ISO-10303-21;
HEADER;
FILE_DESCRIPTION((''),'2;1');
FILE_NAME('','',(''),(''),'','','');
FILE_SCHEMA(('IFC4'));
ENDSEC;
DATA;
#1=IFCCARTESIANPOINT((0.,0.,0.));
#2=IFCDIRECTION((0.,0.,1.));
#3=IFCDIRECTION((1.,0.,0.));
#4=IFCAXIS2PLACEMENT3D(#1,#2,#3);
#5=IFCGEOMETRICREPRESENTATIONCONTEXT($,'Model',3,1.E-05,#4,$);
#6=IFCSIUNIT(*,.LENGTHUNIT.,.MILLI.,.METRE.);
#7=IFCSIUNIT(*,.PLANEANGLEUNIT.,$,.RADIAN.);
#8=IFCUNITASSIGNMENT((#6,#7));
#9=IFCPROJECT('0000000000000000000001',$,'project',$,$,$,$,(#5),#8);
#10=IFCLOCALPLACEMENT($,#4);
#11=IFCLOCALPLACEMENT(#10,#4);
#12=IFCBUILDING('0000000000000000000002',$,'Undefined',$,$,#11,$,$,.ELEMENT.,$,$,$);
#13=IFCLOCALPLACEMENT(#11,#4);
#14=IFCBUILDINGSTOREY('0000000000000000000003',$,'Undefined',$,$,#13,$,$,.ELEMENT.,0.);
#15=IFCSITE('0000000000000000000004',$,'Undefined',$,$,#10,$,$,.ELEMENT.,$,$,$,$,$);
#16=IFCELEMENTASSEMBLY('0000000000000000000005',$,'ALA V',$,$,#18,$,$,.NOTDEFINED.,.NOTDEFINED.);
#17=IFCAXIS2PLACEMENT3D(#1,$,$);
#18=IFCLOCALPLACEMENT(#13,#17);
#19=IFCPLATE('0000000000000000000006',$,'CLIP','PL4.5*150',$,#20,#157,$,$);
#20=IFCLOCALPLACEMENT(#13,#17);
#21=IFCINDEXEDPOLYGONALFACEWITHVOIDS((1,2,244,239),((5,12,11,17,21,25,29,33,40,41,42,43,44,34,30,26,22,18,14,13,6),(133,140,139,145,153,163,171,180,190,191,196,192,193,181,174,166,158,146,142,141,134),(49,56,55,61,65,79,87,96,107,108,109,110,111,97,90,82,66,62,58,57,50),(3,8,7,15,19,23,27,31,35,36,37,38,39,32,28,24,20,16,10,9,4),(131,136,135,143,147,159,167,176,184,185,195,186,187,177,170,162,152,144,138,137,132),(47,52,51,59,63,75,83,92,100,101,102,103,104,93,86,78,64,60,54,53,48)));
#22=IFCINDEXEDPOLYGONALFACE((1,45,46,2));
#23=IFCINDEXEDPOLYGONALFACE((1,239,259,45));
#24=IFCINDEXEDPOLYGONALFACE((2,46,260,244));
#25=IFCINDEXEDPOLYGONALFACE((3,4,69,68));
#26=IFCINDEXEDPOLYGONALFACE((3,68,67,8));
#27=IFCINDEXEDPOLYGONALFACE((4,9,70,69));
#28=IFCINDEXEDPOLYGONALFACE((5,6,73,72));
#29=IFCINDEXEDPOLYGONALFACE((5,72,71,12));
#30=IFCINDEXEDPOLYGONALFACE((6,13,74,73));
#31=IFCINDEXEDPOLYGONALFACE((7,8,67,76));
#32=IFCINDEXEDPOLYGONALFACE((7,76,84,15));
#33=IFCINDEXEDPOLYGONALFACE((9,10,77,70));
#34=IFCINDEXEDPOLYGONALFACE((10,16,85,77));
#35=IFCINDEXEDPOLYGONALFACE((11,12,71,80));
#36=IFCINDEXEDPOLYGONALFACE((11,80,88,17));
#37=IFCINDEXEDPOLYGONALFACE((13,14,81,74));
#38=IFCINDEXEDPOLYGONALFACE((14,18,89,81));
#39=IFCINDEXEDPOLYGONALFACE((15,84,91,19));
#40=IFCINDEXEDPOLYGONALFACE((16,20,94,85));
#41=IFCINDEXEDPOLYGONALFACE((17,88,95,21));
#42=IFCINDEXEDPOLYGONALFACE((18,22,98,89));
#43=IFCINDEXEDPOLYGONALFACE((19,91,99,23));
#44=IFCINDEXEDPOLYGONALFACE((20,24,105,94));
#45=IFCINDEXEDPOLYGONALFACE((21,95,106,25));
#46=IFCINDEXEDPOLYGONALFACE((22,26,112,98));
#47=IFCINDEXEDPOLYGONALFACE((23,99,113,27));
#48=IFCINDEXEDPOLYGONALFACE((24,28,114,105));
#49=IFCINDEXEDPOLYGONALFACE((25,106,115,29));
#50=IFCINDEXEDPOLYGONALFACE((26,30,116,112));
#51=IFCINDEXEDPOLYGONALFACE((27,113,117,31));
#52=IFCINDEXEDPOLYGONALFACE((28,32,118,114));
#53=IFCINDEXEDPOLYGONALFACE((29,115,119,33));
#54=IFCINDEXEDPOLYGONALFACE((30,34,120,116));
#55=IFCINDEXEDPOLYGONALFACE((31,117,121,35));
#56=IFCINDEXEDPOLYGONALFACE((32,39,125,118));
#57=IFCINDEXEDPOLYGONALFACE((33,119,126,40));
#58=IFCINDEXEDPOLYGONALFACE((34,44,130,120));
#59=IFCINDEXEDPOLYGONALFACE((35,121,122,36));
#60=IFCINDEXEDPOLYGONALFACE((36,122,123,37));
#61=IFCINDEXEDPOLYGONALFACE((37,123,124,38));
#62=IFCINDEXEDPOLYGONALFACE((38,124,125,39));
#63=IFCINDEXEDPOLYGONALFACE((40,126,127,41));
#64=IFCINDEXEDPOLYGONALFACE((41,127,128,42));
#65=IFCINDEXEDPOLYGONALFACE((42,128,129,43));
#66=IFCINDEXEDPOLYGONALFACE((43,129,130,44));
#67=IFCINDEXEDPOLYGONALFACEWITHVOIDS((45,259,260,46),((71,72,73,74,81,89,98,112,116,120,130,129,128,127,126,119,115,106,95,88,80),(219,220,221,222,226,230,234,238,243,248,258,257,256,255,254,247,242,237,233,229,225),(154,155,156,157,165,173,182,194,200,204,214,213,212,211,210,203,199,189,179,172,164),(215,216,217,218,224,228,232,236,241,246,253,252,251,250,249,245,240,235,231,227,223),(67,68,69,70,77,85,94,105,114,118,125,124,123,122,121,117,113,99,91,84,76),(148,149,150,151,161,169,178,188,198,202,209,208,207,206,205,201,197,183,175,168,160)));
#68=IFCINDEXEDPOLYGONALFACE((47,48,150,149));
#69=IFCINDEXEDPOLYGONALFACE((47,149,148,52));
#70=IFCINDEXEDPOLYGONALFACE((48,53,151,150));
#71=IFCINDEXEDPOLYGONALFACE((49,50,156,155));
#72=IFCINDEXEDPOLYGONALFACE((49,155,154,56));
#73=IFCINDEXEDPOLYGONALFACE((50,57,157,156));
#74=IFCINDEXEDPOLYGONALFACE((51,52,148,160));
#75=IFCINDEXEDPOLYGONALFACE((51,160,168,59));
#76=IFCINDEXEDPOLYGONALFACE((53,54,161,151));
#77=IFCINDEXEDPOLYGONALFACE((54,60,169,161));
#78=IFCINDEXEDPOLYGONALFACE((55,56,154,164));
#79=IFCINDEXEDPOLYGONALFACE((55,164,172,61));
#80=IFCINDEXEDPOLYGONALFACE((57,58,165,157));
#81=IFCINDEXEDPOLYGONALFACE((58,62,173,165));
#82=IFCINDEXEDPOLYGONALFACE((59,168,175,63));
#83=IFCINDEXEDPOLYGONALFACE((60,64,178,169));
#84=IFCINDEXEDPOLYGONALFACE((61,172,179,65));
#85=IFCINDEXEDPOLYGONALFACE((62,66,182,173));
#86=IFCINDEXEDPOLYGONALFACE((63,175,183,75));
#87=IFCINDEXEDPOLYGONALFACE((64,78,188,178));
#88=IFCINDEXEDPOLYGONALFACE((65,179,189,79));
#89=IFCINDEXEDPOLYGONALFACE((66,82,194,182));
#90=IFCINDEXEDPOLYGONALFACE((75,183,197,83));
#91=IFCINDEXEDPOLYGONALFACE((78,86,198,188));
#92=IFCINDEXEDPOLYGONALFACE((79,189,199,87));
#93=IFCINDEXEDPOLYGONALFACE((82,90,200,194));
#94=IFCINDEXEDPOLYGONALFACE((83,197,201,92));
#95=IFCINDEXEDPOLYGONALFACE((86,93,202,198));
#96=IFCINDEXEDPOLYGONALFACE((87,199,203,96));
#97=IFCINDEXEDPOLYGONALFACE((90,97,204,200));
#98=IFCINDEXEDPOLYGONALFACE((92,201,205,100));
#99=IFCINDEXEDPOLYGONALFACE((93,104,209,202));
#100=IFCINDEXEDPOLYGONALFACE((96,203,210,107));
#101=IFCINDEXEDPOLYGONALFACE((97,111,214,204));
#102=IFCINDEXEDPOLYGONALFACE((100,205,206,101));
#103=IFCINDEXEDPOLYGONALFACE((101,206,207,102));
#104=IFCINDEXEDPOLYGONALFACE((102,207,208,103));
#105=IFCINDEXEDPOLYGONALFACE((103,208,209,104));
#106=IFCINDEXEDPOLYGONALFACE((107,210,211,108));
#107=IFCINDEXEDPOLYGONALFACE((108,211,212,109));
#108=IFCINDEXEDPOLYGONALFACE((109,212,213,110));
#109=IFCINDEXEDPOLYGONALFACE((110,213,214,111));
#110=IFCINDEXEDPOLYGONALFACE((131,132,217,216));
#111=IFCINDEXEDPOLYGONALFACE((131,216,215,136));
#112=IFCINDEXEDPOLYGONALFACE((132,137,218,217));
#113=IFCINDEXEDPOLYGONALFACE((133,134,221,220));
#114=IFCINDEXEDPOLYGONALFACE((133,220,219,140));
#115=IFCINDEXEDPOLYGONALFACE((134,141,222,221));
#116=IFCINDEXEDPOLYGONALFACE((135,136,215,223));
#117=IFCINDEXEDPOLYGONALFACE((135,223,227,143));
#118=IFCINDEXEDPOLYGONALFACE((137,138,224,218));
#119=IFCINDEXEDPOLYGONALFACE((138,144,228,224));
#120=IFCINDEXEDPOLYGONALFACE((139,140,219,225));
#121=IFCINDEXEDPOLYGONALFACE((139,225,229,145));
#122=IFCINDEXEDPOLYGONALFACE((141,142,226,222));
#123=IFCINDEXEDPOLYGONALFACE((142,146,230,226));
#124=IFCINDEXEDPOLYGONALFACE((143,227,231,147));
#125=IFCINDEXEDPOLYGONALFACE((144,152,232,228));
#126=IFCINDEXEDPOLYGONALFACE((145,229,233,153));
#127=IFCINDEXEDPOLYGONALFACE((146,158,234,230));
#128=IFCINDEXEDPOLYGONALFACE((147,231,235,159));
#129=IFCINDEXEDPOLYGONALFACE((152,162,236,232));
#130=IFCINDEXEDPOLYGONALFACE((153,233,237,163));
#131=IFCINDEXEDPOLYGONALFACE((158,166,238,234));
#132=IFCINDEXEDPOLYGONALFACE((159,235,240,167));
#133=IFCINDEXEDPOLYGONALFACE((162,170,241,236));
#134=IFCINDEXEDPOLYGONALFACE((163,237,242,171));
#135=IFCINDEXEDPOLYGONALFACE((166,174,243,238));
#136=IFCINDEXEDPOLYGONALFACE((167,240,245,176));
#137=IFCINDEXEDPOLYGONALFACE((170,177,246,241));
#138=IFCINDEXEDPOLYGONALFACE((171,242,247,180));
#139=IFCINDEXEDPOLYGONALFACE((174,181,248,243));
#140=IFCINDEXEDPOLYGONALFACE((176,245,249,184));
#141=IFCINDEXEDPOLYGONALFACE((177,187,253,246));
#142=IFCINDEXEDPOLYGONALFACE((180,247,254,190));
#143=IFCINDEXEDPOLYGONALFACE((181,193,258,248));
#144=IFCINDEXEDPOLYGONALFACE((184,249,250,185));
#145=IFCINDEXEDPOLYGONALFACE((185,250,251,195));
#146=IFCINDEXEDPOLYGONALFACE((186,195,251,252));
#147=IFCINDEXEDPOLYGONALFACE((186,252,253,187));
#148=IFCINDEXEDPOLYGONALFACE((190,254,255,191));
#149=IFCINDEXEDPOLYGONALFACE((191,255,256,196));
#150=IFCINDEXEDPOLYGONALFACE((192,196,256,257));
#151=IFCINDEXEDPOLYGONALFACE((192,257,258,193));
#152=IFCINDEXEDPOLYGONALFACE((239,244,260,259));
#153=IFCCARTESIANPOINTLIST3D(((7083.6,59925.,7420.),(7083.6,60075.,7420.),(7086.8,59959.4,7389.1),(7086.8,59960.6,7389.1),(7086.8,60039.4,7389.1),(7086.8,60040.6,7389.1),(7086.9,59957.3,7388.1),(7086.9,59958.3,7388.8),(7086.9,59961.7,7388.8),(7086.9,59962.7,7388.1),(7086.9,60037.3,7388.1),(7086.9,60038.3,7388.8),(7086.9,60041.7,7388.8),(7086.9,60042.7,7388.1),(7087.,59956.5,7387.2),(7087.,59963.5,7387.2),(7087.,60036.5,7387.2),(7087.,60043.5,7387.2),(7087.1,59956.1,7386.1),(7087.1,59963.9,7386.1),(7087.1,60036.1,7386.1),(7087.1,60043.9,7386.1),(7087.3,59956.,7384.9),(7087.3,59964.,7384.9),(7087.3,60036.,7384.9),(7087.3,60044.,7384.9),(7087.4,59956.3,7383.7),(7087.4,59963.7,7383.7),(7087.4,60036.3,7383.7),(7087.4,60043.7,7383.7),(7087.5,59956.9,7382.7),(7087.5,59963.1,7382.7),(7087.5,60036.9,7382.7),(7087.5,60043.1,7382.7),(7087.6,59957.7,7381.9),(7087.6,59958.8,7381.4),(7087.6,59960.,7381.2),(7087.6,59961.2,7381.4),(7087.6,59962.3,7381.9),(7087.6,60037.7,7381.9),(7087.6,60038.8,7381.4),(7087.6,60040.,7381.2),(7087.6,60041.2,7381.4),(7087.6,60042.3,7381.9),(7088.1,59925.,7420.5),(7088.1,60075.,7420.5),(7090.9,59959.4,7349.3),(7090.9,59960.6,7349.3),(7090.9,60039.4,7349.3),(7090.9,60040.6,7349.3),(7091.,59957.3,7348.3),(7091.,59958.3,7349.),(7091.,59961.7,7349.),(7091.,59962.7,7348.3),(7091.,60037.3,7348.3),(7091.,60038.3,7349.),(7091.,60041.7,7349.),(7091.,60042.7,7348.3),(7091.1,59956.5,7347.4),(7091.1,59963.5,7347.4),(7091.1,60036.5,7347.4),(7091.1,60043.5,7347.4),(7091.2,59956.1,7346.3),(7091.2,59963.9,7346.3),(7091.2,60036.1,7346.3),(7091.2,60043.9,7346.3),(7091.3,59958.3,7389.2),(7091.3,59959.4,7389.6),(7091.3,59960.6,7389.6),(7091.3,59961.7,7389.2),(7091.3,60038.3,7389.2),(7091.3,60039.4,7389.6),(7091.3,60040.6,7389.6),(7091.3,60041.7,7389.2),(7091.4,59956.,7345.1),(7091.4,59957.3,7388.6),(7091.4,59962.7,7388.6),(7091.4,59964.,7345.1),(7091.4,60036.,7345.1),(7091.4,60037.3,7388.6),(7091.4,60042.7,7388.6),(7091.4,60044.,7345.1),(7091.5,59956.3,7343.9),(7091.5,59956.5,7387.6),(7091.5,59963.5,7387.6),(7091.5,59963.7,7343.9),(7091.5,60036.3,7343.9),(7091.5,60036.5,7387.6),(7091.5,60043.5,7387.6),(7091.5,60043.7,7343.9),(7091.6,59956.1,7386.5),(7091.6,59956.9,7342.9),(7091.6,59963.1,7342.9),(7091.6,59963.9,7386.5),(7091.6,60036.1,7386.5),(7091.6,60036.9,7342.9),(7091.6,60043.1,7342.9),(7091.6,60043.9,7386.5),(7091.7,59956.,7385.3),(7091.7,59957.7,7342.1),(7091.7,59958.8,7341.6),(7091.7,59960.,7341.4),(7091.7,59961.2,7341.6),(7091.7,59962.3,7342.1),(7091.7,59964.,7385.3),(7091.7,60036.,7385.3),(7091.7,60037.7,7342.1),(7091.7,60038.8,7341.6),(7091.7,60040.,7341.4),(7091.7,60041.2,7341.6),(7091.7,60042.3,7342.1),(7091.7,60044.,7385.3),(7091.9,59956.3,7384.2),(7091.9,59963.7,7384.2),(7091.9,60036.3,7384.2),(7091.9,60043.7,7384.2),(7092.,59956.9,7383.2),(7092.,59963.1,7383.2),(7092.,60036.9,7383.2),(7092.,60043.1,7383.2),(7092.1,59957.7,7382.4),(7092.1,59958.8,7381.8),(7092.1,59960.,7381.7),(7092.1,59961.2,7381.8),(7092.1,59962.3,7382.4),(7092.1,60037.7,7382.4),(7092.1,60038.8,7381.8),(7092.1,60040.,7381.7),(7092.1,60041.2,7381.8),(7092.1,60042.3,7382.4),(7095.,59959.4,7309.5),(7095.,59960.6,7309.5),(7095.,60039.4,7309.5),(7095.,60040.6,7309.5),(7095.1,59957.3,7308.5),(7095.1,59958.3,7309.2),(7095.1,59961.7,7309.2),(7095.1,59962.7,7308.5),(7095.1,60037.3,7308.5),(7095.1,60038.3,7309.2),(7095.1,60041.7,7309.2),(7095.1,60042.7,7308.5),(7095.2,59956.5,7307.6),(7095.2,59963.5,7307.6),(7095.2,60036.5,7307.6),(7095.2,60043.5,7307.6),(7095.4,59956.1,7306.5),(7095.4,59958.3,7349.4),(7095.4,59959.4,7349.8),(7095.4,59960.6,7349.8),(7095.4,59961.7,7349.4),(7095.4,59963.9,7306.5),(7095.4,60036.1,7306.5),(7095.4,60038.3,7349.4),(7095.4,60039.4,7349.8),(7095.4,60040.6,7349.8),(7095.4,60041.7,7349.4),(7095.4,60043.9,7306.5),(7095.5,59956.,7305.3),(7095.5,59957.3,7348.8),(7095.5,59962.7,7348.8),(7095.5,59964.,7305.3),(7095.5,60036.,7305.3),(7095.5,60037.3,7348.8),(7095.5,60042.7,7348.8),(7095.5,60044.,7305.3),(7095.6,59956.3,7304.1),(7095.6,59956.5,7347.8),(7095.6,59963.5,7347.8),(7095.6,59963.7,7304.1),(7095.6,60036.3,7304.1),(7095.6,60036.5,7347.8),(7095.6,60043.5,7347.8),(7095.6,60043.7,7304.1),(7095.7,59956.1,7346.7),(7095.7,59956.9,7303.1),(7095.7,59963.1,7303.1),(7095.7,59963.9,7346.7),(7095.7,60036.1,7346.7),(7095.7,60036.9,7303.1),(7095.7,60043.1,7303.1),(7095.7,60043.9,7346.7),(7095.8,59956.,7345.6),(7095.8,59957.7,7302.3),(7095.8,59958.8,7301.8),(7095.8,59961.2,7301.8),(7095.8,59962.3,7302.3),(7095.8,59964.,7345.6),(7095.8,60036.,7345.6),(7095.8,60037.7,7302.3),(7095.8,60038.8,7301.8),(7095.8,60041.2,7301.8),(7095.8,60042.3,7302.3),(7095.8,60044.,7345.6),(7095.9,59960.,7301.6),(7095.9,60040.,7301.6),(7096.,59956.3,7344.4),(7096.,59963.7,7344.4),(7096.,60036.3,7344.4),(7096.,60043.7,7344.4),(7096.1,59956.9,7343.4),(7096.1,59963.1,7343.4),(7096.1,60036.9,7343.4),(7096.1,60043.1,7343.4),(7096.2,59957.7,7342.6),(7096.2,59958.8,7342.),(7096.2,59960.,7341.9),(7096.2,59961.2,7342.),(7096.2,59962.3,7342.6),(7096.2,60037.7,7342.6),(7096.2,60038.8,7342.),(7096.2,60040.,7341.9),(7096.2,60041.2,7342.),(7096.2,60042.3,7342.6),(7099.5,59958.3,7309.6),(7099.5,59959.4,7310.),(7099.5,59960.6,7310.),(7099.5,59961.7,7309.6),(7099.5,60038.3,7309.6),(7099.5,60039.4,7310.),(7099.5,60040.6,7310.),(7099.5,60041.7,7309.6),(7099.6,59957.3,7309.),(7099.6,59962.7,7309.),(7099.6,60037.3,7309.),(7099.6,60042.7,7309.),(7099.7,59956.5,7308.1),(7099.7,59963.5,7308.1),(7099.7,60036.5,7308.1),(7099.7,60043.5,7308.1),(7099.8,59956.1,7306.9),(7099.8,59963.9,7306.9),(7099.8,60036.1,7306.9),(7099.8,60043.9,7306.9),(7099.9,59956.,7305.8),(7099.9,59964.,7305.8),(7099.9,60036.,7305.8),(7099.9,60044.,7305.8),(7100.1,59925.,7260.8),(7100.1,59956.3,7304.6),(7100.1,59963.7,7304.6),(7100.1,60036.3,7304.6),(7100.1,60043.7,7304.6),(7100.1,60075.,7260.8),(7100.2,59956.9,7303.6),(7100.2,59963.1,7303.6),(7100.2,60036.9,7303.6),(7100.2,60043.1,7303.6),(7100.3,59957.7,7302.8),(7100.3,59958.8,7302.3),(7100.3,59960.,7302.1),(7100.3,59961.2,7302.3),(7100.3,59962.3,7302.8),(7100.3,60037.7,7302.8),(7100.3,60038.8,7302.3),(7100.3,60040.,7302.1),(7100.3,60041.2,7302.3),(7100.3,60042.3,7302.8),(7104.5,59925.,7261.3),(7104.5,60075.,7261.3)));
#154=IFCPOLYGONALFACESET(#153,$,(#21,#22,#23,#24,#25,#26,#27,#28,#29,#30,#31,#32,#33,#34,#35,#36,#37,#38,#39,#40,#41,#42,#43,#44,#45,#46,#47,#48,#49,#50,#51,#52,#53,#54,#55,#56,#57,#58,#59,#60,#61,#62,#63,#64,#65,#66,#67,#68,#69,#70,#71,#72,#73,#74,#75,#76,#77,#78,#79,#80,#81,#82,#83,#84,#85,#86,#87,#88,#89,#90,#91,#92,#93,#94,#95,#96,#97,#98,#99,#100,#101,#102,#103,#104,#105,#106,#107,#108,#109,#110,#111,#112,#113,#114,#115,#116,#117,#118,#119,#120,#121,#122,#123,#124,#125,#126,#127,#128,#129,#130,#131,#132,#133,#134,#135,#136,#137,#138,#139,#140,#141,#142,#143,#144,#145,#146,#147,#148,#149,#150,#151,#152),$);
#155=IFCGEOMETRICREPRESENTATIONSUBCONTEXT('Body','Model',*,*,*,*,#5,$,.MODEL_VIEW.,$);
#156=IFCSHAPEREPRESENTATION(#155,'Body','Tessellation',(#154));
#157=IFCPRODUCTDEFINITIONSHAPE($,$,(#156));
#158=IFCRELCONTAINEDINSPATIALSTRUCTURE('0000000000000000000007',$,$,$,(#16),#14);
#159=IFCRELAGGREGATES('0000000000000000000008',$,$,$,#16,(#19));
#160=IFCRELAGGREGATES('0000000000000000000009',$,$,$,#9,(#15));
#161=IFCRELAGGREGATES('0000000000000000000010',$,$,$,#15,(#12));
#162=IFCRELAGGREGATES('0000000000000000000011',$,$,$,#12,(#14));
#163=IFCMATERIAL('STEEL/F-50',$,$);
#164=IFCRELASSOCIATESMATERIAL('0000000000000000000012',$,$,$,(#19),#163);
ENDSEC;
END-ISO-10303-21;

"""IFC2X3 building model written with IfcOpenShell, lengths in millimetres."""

from ifc_helpers import new_model, si_unit, frame, origin_with_axes, origin_2d_with_axis, place, context, subcontext, project, spatial, polyline, circle, outline, extrude, source, transform, mapped, material, element, aggregate, save


model = new_model("IFC2X3")

# Units and contexts
model_context = context("Model", 3, precision=1e-05, world=origin_with_axes())
body_context = subcontext(model_context, "Body", "Model", "MODEL_VIEW")
ifc_project = project(units=[si_unit("LENGTHUNIT", "METRE", prefix="MILLI"), si_unit("PLANEANGLEUNIT", "RADIAN")], contexts=[model_context])

# Site, building, storey
site_placement = place(None, origin_with_axes())
site = spatial("IfcSite", under=ifc_project, at=site_placement, Name="Undefined", CompositionType="ELEMENT")
building_placement = place(site_placement, origin_with_axes())
building = spatial("IfcBuilding", under=site, at=building_placement, Name="Undefined", CompositionType="ELEMENT")
storey_placement = place(building_placement, origin_with_axes())
storey = spatial("IfcBuildingStorey", under=building, at=storey_placement, Name="Undefined", CompositionType="ELEMENT", Elevation=0.0)

# Element assembly
assembly_1_placement = place(storey_placement, origin_with_axes())
assembly_1 = element("IfcElementAssembly", 1, at=assembly_1_placement, inside=storey, Name="ALA V", AssemblyPlace="NOTDEFINED", PredefinedType="NOTDEFINED")
ifc_material_1 = material(Name="STEEL/F-50")

# Plate, openings
shared_shape_1 = source(origin_with_axes(), body_context, "Body", "SweptSolid", [
    extrude(circle(Radius=4.0, at=origin_2d_with_axis()), frame((0.0, -4.6, 0.0), z_axis=(0.0, 1.0, 0.0), x_axis=(1.0, 0.0, 0.0)), (0.0, 0.0, 1.0), 4.7),
])
plate_1_placement = place(assembly_1_placement, frame((7085.9, 59925.0, 7420.2), z_axis=(0.994727, 0.0, 0.102562), x_axis=(0.102562, 0.0, -0.994727)))
plate_1 = element("IfcPlate", 2, at=plate_1_placement, material=ifc_material_1, Name="CLIP", Description="PL4.5*150", context=body_context, shape_type="SweptSolid", body=[
    extrude(outline(polyline([(0.0, 0.0), (160.0, 0.0), (160.0, 150.0), (0.0, 150.0), (0.0, 0.0)])), frame((0.0, 0.0, -2.2), z_axis=(0.0, 0.0, 1.0), x_axis=(1.0, 0.0, 0.0)), (0.0, 0.0, 1.0), 4.5),
])
opening_1_placement = place(assembly_1_placement, frame((7087.2, 60040.0, 7385.2), z_axis=(0.0, 1.0, 0.0), x_axis=(0.102562, 0.0, -0.994727)))
element("IfcOpeningElement", 3, at=opening_1_placement, cuts=plate_1, ObjectType="Opening", context=body_context, shape_type="MappedRepresentation", body=[
    mapped(shared_shape_1, transform((0.0, 0.0, 0.0))),
    mapped(shared_shape_1, transform((40.0, 0.0, 0.0))),
    mapped(shared_shape_1, transform((80.0, 0.0, 0.0))),
])
opening_2_placement = place(assembly_1_placement, frame((7087.2, 59960.0, 7385.2), z_axis=(0.0, 1.0, 0.0), x_axis=(0.102562, 0.0, -0.994727)))
element("IfcOpeningElement", 4, at=opening_2_placement, cuts=plate_1, ObjectType="Opening", context=body_context, shape_type="MappedRepresentation", body=[
    mapped(shared_shape_1, transform((0.0, 0.0, 0.0))),
    mapped(shared_shape_1, transform((40.0, 0.0, 0.0))),
    mapped(shared_shape_1, transform((80.0, 0.0, 0.0))),
])

aggregate(assembly_1, [plate_1])

save(model, "model.ifc")
